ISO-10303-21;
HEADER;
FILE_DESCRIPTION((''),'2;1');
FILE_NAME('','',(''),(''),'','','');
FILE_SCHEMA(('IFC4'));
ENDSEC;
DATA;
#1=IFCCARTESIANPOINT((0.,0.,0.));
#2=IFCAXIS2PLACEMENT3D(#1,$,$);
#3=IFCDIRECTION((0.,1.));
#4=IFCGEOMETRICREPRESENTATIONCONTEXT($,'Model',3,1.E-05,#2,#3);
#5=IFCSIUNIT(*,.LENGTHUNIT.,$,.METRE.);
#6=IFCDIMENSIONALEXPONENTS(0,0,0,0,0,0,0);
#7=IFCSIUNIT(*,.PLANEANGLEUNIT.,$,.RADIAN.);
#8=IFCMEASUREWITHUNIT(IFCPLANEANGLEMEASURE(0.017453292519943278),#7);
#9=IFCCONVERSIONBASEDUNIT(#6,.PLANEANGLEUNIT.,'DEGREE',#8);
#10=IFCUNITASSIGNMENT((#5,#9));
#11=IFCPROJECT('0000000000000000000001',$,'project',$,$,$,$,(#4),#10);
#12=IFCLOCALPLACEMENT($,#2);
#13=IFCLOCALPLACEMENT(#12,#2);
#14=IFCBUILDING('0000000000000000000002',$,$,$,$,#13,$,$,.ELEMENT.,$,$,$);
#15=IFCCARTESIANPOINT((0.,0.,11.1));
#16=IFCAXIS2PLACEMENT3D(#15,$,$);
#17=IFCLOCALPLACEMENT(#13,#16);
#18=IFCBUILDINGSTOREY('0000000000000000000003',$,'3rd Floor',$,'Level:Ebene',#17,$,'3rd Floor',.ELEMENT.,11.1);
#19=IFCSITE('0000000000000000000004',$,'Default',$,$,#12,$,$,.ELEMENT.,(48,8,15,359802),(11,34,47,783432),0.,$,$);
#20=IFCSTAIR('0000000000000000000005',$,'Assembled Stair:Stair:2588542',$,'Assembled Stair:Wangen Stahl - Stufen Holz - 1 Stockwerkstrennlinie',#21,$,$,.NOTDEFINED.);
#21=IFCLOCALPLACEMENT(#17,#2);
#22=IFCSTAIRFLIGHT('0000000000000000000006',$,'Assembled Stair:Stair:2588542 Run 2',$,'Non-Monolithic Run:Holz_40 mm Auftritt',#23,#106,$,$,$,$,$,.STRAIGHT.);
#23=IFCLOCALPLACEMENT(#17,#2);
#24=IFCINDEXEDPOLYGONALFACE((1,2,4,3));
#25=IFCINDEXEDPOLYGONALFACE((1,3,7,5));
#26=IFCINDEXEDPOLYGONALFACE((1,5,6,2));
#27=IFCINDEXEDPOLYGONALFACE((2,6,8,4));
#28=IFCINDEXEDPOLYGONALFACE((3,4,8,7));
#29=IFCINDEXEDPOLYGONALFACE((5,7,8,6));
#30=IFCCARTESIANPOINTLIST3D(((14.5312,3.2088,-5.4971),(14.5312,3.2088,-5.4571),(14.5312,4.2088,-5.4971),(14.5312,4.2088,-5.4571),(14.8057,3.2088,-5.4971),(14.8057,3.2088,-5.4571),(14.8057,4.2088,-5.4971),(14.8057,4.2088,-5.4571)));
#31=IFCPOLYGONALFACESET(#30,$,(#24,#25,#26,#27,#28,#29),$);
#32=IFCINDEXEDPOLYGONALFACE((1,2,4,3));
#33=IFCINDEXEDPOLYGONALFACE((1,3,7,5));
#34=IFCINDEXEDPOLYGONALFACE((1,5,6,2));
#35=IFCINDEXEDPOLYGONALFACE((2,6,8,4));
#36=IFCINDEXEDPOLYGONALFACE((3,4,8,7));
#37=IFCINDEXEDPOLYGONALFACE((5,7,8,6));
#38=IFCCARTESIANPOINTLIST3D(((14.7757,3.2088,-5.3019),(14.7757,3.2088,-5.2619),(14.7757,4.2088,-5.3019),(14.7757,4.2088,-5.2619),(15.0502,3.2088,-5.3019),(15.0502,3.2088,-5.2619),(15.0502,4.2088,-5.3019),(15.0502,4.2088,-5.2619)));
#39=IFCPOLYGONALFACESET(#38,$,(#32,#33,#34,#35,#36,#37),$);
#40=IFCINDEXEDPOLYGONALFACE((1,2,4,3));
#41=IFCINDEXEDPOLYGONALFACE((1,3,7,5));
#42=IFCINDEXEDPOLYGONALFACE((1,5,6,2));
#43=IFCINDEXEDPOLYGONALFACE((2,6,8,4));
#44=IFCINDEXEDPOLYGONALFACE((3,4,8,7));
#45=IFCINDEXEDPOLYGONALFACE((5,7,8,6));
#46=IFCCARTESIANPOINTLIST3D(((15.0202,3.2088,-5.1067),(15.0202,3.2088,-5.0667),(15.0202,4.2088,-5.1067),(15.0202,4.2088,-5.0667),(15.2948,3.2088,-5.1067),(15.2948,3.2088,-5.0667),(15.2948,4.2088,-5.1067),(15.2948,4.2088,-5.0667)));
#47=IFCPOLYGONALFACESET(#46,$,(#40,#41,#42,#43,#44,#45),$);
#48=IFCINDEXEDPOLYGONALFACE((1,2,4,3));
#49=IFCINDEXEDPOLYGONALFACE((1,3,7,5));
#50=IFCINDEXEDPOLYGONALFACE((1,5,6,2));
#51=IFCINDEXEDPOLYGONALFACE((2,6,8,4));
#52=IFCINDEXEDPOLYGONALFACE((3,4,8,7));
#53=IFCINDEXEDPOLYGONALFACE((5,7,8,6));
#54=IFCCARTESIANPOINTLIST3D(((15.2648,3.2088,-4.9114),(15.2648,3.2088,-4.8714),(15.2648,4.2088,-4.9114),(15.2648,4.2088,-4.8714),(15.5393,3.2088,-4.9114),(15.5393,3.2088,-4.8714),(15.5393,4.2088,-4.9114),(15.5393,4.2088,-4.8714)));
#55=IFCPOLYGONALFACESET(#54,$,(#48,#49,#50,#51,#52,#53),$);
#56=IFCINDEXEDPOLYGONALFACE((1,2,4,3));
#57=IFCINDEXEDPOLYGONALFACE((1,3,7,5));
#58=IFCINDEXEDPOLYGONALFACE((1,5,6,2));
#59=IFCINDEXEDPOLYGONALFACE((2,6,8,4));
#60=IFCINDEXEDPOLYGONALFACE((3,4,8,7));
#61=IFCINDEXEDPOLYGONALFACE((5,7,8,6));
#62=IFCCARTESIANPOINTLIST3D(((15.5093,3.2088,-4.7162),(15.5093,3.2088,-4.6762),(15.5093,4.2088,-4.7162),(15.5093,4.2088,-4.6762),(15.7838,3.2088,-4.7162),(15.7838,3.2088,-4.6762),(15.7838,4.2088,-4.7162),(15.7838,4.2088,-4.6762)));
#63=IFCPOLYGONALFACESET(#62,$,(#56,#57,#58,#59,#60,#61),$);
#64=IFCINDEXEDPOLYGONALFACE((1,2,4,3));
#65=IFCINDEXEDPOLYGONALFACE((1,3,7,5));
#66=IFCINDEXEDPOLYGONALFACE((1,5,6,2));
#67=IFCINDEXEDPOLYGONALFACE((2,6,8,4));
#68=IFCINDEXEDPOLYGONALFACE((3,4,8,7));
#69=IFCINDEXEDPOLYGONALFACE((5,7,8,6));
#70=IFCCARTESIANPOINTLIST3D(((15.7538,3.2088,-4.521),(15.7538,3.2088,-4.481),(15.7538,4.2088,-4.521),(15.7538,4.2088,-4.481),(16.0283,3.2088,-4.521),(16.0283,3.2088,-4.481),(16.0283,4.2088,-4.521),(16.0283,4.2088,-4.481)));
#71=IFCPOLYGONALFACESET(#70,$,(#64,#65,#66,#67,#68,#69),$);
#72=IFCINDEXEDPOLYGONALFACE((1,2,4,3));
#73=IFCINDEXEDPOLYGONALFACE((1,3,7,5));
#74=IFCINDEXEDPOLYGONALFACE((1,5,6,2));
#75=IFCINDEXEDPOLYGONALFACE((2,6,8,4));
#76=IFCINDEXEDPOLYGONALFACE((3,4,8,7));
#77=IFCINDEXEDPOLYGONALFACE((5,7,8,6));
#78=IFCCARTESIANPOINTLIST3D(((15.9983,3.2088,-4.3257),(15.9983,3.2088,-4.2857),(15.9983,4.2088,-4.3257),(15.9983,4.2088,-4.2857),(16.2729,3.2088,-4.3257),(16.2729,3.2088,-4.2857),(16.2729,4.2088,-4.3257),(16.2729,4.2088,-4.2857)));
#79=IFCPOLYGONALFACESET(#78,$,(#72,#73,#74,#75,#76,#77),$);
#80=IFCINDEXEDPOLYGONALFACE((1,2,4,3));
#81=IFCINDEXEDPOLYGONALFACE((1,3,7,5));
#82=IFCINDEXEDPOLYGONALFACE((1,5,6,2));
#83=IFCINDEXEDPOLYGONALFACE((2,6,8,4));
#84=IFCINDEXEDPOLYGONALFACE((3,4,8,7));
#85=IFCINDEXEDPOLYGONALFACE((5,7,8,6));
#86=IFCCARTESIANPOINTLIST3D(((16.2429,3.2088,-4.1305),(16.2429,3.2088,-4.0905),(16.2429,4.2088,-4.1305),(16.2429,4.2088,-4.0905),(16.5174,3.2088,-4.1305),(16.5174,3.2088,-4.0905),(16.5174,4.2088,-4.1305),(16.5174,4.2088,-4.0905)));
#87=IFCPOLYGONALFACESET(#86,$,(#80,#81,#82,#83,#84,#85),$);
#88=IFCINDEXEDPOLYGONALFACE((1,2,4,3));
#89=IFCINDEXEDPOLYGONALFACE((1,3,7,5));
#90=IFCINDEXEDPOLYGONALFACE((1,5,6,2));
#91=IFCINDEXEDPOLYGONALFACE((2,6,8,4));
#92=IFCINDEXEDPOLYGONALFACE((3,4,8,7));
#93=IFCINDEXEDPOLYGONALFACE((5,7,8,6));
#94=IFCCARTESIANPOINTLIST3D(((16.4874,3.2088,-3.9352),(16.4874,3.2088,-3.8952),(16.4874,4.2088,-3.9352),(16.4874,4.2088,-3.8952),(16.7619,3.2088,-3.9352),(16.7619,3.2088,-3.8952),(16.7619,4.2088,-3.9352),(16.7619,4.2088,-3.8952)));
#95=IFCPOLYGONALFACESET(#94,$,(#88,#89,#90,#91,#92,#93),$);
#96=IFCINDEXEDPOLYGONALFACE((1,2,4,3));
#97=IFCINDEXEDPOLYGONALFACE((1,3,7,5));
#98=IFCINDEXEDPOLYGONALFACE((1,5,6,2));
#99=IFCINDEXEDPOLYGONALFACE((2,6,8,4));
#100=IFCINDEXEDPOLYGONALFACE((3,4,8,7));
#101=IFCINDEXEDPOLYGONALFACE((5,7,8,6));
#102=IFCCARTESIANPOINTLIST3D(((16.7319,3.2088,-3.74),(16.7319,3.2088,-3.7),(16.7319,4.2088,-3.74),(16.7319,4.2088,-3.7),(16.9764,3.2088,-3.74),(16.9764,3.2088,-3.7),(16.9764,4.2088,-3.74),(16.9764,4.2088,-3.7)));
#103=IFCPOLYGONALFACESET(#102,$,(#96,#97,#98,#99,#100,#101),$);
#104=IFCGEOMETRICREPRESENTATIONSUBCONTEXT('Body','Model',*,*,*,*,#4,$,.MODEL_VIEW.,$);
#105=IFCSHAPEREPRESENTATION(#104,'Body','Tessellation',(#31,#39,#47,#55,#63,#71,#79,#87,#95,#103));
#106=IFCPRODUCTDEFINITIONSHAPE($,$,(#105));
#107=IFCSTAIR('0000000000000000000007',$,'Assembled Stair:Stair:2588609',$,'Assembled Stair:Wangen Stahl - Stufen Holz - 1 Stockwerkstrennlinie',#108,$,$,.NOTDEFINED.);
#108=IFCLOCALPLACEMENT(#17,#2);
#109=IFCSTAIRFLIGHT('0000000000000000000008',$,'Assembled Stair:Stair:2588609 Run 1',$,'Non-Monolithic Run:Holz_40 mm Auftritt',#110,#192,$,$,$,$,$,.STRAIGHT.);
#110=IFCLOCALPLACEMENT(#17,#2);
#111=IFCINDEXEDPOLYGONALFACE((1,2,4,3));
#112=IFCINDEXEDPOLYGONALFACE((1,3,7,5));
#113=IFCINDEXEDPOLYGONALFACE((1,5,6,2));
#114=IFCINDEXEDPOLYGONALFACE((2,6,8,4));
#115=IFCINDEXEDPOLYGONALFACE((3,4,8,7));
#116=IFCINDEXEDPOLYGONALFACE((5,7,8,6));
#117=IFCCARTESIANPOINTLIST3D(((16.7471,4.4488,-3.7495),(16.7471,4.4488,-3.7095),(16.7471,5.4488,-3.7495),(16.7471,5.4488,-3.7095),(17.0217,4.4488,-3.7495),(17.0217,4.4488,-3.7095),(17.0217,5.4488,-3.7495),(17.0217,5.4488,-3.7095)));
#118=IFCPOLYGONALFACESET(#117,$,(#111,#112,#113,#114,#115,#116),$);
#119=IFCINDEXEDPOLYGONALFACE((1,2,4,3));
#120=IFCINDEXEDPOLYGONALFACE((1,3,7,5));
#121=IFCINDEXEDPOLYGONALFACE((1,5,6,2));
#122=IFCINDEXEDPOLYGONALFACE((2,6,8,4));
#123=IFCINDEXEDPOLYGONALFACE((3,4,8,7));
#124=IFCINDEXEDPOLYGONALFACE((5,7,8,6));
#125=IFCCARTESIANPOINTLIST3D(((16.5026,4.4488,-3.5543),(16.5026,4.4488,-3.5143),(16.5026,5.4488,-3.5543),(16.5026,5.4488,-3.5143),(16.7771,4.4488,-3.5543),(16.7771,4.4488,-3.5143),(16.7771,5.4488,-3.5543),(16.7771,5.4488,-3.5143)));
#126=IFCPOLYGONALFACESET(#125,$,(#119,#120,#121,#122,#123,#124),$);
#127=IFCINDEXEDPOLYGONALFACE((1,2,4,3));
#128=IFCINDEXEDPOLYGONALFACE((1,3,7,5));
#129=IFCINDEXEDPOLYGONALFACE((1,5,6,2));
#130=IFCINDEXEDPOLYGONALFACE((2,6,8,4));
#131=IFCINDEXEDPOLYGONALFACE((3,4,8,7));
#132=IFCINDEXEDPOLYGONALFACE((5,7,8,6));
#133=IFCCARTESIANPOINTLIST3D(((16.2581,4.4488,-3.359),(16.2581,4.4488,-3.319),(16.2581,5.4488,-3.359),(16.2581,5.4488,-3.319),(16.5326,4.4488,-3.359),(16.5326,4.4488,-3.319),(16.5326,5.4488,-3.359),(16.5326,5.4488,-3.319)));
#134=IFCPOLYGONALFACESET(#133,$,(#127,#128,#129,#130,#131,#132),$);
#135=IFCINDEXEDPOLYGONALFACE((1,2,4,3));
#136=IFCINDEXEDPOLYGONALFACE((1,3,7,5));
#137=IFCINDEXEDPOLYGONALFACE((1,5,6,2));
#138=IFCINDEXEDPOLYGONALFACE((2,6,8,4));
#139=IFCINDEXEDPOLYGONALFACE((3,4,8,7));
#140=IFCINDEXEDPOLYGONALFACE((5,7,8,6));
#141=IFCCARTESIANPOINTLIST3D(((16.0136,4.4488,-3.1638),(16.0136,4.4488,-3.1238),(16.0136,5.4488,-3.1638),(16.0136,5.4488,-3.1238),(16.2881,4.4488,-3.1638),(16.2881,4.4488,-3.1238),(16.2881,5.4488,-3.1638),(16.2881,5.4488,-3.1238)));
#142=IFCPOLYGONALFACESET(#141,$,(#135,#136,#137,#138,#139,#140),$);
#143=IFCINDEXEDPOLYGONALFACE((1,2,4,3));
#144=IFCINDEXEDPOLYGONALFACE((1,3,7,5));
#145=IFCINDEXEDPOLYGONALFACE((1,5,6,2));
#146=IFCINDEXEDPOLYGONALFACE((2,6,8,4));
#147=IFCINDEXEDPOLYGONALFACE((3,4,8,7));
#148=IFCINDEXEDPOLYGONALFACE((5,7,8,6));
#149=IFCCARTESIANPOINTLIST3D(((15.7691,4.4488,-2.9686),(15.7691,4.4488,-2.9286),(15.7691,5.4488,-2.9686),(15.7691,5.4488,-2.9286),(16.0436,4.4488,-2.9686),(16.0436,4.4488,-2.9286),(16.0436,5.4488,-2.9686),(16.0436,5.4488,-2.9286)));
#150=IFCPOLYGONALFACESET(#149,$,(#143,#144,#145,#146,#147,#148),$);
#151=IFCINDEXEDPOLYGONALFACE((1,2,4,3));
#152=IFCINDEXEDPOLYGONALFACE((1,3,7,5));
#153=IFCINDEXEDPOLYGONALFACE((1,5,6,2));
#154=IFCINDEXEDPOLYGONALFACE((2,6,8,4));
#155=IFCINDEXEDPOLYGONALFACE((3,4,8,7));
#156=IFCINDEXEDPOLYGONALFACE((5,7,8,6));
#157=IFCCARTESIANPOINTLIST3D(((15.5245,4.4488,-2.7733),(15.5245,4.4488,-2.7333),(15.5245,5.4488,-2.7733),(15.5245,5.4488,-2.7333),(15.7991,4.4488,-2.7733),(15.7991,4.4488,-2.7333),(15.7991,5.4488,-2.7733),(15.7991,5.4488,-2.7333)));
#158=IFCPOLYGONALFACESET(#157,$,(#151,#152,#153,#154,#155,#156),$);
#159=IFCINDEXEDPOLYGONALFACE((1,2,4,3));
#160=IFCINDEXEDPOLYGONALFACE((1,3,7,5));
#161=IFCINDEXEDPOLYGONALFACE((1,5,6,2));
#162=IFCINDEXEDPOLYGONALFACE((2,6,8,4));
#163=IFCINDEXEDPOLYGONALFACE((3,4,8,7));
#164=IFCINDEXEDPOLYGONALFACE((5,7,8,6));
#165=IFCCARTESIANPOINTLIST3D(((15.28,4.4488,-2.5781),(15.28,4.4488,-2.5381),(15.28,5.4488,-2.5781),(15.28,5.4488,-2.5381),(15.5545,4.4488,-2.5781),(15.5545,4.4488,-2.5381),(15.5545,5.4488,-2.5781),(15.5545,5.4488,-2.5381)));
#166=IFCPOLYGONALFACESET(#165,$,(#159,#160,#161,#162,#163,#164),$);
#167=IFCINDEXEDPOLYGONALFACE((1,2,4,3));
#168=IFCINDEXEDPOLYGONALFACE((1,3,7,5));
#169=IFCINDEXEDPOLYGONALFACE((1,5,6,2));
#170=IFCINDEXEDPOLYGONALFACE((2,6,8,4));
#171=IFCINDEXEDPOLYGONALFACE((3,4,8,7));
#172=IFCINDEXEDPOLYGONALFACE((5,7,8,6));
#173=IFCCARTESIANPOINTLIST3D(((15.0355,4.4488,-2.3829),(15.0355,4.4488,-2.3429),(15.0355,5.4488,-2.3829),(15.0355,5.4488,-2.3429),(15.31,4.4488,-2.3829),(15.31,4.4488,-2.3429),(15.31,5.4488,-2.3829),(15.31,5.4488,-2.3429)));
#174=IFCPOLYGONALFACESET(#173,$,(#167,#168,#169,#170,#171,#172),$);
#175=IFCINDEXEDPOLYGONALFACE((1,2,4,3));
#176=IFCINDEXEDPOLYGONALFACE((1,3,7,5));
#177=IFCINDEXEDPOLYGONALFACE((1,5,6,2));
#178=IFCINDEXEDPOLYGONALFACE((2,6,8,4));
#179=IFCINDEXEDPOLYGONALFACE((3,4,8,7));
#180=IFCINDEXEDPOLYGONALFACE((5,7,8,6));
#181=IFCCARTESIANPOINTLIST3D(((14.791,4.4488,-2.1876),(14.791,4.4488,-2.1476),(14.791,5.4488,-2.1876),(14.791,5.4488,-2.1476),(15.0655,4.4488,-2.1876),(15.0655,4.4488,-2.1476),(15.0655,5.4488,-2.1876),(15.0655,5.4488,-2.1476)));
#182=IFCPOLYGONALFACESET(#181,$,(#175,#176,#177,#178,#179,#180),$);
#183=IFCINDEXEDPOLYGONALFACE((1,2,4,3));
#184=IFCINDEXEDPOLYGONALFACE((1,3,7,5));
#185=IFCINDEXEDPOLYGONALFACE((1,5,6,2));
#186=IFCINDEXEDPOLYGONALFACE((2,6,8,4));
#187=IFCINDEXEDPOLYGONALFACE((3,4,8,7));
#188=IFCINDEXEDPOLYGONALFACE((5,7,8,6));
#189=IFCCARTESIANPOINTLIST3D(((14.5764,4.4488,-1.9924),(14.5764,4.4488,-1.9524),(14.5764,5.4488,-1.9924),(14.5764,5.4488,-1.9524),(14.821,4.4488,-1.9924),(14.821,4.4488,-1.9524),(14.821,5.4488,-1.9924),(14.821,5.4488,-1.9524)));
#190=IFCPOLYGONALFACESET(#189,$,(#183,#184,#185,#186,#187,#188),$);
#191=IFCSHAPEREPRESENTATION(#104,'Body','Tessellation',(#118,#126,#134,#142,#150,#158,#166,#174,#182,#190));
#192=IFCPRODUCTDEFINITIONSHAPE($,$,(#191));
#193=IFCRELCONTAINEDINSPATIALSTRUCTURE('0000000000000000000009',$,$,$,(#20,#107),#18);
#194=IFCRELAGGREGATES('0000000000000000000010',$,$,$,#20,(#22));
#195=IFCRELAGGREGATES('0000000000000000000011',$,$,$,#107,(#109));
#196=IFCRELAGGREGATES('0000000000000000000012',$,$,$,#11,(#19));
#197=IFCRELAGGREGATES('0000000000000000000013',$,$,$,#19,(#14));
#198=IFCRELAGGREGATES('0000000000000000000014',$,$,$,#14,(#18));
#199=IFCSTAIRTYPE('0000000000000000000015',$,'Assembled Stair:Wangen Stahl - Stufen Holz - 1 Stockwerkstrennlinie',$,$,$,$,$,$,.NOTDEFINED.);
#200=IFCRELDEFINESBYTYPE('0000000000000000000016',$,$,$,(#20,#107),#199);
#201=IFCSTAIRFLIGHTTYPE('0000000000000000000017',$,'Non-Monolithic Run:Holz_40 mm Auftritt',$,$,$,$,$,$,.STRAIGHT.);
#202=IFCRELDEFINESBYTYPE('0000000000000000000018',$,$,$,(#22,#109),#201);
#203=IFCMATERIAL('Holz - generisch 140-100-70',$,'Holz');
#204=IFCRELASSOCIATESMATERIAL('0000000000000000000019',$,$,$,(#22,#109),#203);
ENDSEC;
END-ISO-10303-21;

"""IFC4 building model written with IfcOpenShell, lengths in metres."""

from ifc_helpers import new_model, entity, si_unit, converted_unit, direction, frame, origin, place, context, subcontext, project, spatial, indexed_curve, outline, extrude, material, type_object, element, aggregate, save


model = new_model("IFC4")

# Units and contexts
model_context = context("Model", 3, precision=1e-05, world=origin(), true_north=direction((0.0, 1.0)))
body_context = subcontext(model_context, "Body", "Model", "MODEL_VIEW")
ifc_project = project(units=[si_unit("LENGTHUNIT", "METRE"), converted_unit("PLANEANGLEUNIT", "DEGREE", entity("IfcPlaneAngleMeasure", 0.017453292519943278), si_unit("PLANEANGLEUNIT", "RADIAN"), dimensions=[0, 0, 0, 0, 0, 0, 0])], contexts=[model_context])

# Site, building, storey
site_placement = place(None, origin())
site = spatial("IfcSite", under=ifc_project, at=site_placement, Name="Default", CompositionType="ELEMENT", RefLatitude=(48, 8, 15, 359802), RefLongitude=(11, 34, 47, 783432), RefElevation=0.0)
building_placement = place(site_placement, origin())
building = spatial("IfcBuilding", under=site, at=building_placement, CompositionType="ELEMENT")
storey_placement = place(building_placement, frame((0.0, 0.0, 11.1)))
storey = spatial("IfcBuildingStorey", under=building, at=storey_placement, Name="3rd Floor", ObjectType="Level:Ebene", LongName="3rd Floor", CompositionType="ELEMENT", Elevation=11.1)

# Shared definitions
stair_type = type_object("IfcStairType", Name="Assembled Stair:Wangen Stahl - Stufen Holz - 1 Stockwerkstrennlinie", PredefinedType="NOTDEFINED")

# Stair, stair flight
stair_1_placement = place(storey_placement, origin())
stair_1 = element("IfcStair", 1, at=stair_1_placement, inside=storey, type_object=stair_type, Name="Assembled Stair:Stair:2588542", ObjectType="Assembled Stair:Wangen Stahl - Stufen Holz - 1 Stockwerkstrennlinie", PredefinedType="NOTDEFINED")
ifc_material_1 = material(Name="Holz - generisch 140-100-70", Category="Holz")
stair_flight_type = type_object("IfcStairFlightType", Name="Non-Monolithic Run:Holz_40 mm Auftritt", PredefinedType="STRAIGHT")
stair_flight_1_placement = place(stair_1_placement, origin())
stair_flight_1 = element("IfcStairFlight", 2, at=stair_flight_1_placement, type_object=stair_flight_type, material=ifc_material_1, Name="Assembled Stair:Stair:2588542 Run 2", ObjectType="Non-Monolithic Run:Holz_40 mm Auftritt", PredefinedType="STRAIGHT", context=body_context, shape_type="SweptSolid", body=[
    extrude(outline(indexed_curve([(-0.1373, -0.5), (0.1373, -0.5), (0.1373, 0.5), (-0.1373, 0.5), (-0.1373, -0.5)], self_intersect=False)), frame((14.6685, 3.7088, -5.4971), z_axis=(0.0, 0.0, 1.0), x_axis=(-1.0, 0.0, 0.0)), (0.0, 0.0, 1.0), 0.04),
    extrude(outline(indexed_curve([(-0.1373, -0.5), (0.1373, -0.5), (0.1373, 0.5), (-0.1373, 0.5), (-0.1373, -0.5)], self_intersect=False)), frame((14.913, 3.7088, -5.3019), z_axis=(0.0, 0.0, 1.0), x_axis=(-1.0, 0.0, 0.0)), (0.0, 0.0, 1.0), 0.04),
    extrude(outline(indexed_curve([(-0.1373, -0.5), (0.1373, -0.5), (0.1373, 0.5), (-0.1373, 0.5), (-0.1373, -0.5)], self_intersect=False)), frame((15.1575, 3.7088, -5.1067), z_axis=(0.0, 0.0, 1.0), x_axis=(-1.0, 0.0, 0.0)), (0.0, 0.0, 1.0), 0.04),
    extrude(outline(indexed_curve([(-0.1373, -0.5), (0.1373, -0.5), (0.1373, 0.5), (-0.1373, 0.5), (-0.1373, -0.5)], self_intersect=False)), frame((15.402, 3.7088, -4.9114), z_axis=(0.0, 0.0, 1.0), x_axis=(-1.0, 0.0, 0.0)), (0.0, 0.0, 1.0), 0.04),
    extrude(outline(indexed_curve([(-0.1373, -0.5), (0.1373, -0.5), (0.1373, 0.5), (-0.1373, 0.5), (-0.1373, -0.5)], self_intersect=False)), frame((15.6466, 3.7088, -4.7162), z_axis=(0.0, 0.0, 1.0), x_axis=(-1.0, 0.0, 0.0)), (0.0, 0.0, 1.0), 0.04),
    extrude(outline(indexed_curve([(-0.1373, -0.5), (0.1373, -0.5), (0.1373, 0.5), (-0.1373, 0.5), (-0.1373, -0.5)], self_intersect=False)), frame((15.8911, 3.7088, -4.521), z_axis=(0.0, 0.0, 1.0), x_axis=(-1.0, 0.0, 0.0)), (0.0, 0.0, 1.0), 0.04),
    extrude(outline(indexed_curve([(-0.1373, -0.5), (0.1373, -0.5), (0.1373, 0.5), (-0.1373, 0.5), (-0.1373, -0.5)], self_intersect=False)), frame((16.1356, 3.7088, -4.3257), z_axis=(0.0, 0.0, 1.0), x_axis=(-1.0, 0.0, 0.0)), (0.0, 0.0, 1.0), 0.04),
    extrude(outline(indexed_curve([(-0.1373, -0.5), (0.1373, -0.5), (0.1373, 0.5), (-0.1373, 0.5), (-0.1373, -0.5)], self_intersect=False)), frame((16.3801, 3.7088, -4.1305), z_axis=(0.0, 0.0, 1.0), x_axis=(-1.0, 0.0, 0.0)), (0.0, 0.0, 1.0), 0.04),
    extrude(outline(indexed_curve([(-0.1373, -0.5), (0.1373, -0.5), (0.1373, 0.5), (-0.1373, 0.5), (-0.1373, -0.5)], self_intersect=False)), frame((16.6246, 3.7088, -3.9352), z_axis=(0.0, 0.0, 1.0), x_axis=(-1.0, 0.0, 0.0)), (0.0, 0.0, 1.0), 0.04),
    extrude(outline(indexed_curve([(-0.1223, -0.5), (0.1223, -0.5), (0.1223, 0.5), (-0.1223, 0.5), (-0.1223, -0.5)], self_intersect=False)), frame((16.8542, 3.7088, -3.74), z_axis=(0.0, 0.0, 1.0), x_axis=(-1.0, 0.0, 0.0)), (0.0, 0.0, 1.0), 0.04),
])
aggregate(stair_1, [stair_flight_1])

# Stair, stair flight
stair_2_placement = place(storey_placement, origin())
stair_2 = element("IfcStair", 3, at=stair_2_placement, inside=storey, type_object=stair_type, Name="Assembled Stair:Stair:2588609", ObjectType="Assembled Stair:Wangen Stahl - Stufen Holz - 1 Stockwerkstrennlinie", PredefinedType="NOTDEFINED")
stair_flight_2_placement = place(stair_2_placement, origin())
stair_flight_2 = element("IfcStairFlight", 4, at=stair_flight_2_placement, type_object=stair_flight_type, material=ifc_material_1, Name="Assembled Stair:Stair:2588609 Run 1", ObjectType="Non-Monolithic Run:Holz_40 mm Auftritt", PredefinedType="STRAIGHT", context=body_context, shape_type="SweptSolid", body=[
    extrude(outline(indexed_curve([(-0.1373, -0.5), (0.1373, -0.5), (0.1373, 0.5), (-0.1373, 0.5), (-0.1373, -0.5)], self_intersect=False)), frame((16.8844, 4.9488, -3.7495)), (0.0, 0.0, 1.0), 0.04),
    extrude(outline(indexed_curve([(-0.1373, -0.5), (0.1373, -0.5), (0.1373, 0.5), (-0.1373, 0.5), (-0.1373, -0.5)], self_intersect=False)), frame((16.6399, 4.9488, -3.5543)), (0.0, 0.0, 1.0), 0.04),
    extrude(outline(indexed_curve([(-0.1373, -0.5), (0.1373, -0.5), (0.1373, 0.5), (-0.1373, 0.5), (-0.1373, -0.5)], self_intersect=False)), frame((16.3954, 4.9488, -3.359)), (0.0, 0.0, 1.0), 0.04),
    extrude(outline(indexed_curve([(-0.1373, -0.5), (0.1373, -0.5), (0.1373, 0.5), (-0.1373, 0.5), (-0.1373, -0.5)], self_intersect=False)), frame((16.1508, 4.9488, -3.1638)), (0.0, 0.0, 1.0), 0.04),
    extrude(outline(indexed_curve([(-0.1373, -0.5), (0.1373, -0.5), (0.1373, 0.5), (-0.1373, 0.5), (-0.1373, -0.5)], self_intersect=False)), frame((15.9063, 4.9488, -2.9686)), (0.0, 0.0, 1.0), 0.04),
    extrude(outline(indexed_curve([(-0.1373, -0.5), (0.1373, -0.5), (0.1373, 0.5), (-0.1373, 0.5), (-0.1373, -0.5)], self_intersect=False)), frame((15.6618, 4.9488, -2.7733)), (0.0, 0.0, 1.0), 0.04),
    extrude(outline(indexed_curve([(-0.1373, -0.5), (0.1373, -0.5), (0.1373, 0.5), (-0.1373, 0.5), (-0.1373, -0.5)], self_intersect=False)), frame((15.4173, 4.9488, -2.5781)), (0.0, 0.0, 1.0), 0.04),
    extrude(outline(indexed_curve([(-0.1373, -0.5), (0.1373, -0.5), (0.1373, 0.5), (-0.1373, 0.5), (-0.1373, -0.5)], self_intersect=False)), frame((15.1727, 4.9488, -2.3829)), (0.0, 0.0, 1.0), 0.04),
    extrude(outline(indexed_curve([(-0.1373, -0.5), (0.1373, -0.5), (0.1373, 0.5), (-0.1373, 0.5), (-0.1373, -0.5)], self_intersect=False)), frame((14.9282, 4.9488, -2.1876)), (0.0, 0.0, 1.0), 0.04),
    extrude(outline(indexed_curve([(-0.1223, -0.5), (0.1223, -0.5), (0.1223, 0.5), (-0.1223, 0.5), (-0.1223, -0.5)], self_intersect=False)), frame((14.6987, 4.9488, -1.9924)), (0.0, 0.0, 1.0), 0.04),
])
aggregate(stair_2, [stair_flight_2])

save(model, "model.ifc")
